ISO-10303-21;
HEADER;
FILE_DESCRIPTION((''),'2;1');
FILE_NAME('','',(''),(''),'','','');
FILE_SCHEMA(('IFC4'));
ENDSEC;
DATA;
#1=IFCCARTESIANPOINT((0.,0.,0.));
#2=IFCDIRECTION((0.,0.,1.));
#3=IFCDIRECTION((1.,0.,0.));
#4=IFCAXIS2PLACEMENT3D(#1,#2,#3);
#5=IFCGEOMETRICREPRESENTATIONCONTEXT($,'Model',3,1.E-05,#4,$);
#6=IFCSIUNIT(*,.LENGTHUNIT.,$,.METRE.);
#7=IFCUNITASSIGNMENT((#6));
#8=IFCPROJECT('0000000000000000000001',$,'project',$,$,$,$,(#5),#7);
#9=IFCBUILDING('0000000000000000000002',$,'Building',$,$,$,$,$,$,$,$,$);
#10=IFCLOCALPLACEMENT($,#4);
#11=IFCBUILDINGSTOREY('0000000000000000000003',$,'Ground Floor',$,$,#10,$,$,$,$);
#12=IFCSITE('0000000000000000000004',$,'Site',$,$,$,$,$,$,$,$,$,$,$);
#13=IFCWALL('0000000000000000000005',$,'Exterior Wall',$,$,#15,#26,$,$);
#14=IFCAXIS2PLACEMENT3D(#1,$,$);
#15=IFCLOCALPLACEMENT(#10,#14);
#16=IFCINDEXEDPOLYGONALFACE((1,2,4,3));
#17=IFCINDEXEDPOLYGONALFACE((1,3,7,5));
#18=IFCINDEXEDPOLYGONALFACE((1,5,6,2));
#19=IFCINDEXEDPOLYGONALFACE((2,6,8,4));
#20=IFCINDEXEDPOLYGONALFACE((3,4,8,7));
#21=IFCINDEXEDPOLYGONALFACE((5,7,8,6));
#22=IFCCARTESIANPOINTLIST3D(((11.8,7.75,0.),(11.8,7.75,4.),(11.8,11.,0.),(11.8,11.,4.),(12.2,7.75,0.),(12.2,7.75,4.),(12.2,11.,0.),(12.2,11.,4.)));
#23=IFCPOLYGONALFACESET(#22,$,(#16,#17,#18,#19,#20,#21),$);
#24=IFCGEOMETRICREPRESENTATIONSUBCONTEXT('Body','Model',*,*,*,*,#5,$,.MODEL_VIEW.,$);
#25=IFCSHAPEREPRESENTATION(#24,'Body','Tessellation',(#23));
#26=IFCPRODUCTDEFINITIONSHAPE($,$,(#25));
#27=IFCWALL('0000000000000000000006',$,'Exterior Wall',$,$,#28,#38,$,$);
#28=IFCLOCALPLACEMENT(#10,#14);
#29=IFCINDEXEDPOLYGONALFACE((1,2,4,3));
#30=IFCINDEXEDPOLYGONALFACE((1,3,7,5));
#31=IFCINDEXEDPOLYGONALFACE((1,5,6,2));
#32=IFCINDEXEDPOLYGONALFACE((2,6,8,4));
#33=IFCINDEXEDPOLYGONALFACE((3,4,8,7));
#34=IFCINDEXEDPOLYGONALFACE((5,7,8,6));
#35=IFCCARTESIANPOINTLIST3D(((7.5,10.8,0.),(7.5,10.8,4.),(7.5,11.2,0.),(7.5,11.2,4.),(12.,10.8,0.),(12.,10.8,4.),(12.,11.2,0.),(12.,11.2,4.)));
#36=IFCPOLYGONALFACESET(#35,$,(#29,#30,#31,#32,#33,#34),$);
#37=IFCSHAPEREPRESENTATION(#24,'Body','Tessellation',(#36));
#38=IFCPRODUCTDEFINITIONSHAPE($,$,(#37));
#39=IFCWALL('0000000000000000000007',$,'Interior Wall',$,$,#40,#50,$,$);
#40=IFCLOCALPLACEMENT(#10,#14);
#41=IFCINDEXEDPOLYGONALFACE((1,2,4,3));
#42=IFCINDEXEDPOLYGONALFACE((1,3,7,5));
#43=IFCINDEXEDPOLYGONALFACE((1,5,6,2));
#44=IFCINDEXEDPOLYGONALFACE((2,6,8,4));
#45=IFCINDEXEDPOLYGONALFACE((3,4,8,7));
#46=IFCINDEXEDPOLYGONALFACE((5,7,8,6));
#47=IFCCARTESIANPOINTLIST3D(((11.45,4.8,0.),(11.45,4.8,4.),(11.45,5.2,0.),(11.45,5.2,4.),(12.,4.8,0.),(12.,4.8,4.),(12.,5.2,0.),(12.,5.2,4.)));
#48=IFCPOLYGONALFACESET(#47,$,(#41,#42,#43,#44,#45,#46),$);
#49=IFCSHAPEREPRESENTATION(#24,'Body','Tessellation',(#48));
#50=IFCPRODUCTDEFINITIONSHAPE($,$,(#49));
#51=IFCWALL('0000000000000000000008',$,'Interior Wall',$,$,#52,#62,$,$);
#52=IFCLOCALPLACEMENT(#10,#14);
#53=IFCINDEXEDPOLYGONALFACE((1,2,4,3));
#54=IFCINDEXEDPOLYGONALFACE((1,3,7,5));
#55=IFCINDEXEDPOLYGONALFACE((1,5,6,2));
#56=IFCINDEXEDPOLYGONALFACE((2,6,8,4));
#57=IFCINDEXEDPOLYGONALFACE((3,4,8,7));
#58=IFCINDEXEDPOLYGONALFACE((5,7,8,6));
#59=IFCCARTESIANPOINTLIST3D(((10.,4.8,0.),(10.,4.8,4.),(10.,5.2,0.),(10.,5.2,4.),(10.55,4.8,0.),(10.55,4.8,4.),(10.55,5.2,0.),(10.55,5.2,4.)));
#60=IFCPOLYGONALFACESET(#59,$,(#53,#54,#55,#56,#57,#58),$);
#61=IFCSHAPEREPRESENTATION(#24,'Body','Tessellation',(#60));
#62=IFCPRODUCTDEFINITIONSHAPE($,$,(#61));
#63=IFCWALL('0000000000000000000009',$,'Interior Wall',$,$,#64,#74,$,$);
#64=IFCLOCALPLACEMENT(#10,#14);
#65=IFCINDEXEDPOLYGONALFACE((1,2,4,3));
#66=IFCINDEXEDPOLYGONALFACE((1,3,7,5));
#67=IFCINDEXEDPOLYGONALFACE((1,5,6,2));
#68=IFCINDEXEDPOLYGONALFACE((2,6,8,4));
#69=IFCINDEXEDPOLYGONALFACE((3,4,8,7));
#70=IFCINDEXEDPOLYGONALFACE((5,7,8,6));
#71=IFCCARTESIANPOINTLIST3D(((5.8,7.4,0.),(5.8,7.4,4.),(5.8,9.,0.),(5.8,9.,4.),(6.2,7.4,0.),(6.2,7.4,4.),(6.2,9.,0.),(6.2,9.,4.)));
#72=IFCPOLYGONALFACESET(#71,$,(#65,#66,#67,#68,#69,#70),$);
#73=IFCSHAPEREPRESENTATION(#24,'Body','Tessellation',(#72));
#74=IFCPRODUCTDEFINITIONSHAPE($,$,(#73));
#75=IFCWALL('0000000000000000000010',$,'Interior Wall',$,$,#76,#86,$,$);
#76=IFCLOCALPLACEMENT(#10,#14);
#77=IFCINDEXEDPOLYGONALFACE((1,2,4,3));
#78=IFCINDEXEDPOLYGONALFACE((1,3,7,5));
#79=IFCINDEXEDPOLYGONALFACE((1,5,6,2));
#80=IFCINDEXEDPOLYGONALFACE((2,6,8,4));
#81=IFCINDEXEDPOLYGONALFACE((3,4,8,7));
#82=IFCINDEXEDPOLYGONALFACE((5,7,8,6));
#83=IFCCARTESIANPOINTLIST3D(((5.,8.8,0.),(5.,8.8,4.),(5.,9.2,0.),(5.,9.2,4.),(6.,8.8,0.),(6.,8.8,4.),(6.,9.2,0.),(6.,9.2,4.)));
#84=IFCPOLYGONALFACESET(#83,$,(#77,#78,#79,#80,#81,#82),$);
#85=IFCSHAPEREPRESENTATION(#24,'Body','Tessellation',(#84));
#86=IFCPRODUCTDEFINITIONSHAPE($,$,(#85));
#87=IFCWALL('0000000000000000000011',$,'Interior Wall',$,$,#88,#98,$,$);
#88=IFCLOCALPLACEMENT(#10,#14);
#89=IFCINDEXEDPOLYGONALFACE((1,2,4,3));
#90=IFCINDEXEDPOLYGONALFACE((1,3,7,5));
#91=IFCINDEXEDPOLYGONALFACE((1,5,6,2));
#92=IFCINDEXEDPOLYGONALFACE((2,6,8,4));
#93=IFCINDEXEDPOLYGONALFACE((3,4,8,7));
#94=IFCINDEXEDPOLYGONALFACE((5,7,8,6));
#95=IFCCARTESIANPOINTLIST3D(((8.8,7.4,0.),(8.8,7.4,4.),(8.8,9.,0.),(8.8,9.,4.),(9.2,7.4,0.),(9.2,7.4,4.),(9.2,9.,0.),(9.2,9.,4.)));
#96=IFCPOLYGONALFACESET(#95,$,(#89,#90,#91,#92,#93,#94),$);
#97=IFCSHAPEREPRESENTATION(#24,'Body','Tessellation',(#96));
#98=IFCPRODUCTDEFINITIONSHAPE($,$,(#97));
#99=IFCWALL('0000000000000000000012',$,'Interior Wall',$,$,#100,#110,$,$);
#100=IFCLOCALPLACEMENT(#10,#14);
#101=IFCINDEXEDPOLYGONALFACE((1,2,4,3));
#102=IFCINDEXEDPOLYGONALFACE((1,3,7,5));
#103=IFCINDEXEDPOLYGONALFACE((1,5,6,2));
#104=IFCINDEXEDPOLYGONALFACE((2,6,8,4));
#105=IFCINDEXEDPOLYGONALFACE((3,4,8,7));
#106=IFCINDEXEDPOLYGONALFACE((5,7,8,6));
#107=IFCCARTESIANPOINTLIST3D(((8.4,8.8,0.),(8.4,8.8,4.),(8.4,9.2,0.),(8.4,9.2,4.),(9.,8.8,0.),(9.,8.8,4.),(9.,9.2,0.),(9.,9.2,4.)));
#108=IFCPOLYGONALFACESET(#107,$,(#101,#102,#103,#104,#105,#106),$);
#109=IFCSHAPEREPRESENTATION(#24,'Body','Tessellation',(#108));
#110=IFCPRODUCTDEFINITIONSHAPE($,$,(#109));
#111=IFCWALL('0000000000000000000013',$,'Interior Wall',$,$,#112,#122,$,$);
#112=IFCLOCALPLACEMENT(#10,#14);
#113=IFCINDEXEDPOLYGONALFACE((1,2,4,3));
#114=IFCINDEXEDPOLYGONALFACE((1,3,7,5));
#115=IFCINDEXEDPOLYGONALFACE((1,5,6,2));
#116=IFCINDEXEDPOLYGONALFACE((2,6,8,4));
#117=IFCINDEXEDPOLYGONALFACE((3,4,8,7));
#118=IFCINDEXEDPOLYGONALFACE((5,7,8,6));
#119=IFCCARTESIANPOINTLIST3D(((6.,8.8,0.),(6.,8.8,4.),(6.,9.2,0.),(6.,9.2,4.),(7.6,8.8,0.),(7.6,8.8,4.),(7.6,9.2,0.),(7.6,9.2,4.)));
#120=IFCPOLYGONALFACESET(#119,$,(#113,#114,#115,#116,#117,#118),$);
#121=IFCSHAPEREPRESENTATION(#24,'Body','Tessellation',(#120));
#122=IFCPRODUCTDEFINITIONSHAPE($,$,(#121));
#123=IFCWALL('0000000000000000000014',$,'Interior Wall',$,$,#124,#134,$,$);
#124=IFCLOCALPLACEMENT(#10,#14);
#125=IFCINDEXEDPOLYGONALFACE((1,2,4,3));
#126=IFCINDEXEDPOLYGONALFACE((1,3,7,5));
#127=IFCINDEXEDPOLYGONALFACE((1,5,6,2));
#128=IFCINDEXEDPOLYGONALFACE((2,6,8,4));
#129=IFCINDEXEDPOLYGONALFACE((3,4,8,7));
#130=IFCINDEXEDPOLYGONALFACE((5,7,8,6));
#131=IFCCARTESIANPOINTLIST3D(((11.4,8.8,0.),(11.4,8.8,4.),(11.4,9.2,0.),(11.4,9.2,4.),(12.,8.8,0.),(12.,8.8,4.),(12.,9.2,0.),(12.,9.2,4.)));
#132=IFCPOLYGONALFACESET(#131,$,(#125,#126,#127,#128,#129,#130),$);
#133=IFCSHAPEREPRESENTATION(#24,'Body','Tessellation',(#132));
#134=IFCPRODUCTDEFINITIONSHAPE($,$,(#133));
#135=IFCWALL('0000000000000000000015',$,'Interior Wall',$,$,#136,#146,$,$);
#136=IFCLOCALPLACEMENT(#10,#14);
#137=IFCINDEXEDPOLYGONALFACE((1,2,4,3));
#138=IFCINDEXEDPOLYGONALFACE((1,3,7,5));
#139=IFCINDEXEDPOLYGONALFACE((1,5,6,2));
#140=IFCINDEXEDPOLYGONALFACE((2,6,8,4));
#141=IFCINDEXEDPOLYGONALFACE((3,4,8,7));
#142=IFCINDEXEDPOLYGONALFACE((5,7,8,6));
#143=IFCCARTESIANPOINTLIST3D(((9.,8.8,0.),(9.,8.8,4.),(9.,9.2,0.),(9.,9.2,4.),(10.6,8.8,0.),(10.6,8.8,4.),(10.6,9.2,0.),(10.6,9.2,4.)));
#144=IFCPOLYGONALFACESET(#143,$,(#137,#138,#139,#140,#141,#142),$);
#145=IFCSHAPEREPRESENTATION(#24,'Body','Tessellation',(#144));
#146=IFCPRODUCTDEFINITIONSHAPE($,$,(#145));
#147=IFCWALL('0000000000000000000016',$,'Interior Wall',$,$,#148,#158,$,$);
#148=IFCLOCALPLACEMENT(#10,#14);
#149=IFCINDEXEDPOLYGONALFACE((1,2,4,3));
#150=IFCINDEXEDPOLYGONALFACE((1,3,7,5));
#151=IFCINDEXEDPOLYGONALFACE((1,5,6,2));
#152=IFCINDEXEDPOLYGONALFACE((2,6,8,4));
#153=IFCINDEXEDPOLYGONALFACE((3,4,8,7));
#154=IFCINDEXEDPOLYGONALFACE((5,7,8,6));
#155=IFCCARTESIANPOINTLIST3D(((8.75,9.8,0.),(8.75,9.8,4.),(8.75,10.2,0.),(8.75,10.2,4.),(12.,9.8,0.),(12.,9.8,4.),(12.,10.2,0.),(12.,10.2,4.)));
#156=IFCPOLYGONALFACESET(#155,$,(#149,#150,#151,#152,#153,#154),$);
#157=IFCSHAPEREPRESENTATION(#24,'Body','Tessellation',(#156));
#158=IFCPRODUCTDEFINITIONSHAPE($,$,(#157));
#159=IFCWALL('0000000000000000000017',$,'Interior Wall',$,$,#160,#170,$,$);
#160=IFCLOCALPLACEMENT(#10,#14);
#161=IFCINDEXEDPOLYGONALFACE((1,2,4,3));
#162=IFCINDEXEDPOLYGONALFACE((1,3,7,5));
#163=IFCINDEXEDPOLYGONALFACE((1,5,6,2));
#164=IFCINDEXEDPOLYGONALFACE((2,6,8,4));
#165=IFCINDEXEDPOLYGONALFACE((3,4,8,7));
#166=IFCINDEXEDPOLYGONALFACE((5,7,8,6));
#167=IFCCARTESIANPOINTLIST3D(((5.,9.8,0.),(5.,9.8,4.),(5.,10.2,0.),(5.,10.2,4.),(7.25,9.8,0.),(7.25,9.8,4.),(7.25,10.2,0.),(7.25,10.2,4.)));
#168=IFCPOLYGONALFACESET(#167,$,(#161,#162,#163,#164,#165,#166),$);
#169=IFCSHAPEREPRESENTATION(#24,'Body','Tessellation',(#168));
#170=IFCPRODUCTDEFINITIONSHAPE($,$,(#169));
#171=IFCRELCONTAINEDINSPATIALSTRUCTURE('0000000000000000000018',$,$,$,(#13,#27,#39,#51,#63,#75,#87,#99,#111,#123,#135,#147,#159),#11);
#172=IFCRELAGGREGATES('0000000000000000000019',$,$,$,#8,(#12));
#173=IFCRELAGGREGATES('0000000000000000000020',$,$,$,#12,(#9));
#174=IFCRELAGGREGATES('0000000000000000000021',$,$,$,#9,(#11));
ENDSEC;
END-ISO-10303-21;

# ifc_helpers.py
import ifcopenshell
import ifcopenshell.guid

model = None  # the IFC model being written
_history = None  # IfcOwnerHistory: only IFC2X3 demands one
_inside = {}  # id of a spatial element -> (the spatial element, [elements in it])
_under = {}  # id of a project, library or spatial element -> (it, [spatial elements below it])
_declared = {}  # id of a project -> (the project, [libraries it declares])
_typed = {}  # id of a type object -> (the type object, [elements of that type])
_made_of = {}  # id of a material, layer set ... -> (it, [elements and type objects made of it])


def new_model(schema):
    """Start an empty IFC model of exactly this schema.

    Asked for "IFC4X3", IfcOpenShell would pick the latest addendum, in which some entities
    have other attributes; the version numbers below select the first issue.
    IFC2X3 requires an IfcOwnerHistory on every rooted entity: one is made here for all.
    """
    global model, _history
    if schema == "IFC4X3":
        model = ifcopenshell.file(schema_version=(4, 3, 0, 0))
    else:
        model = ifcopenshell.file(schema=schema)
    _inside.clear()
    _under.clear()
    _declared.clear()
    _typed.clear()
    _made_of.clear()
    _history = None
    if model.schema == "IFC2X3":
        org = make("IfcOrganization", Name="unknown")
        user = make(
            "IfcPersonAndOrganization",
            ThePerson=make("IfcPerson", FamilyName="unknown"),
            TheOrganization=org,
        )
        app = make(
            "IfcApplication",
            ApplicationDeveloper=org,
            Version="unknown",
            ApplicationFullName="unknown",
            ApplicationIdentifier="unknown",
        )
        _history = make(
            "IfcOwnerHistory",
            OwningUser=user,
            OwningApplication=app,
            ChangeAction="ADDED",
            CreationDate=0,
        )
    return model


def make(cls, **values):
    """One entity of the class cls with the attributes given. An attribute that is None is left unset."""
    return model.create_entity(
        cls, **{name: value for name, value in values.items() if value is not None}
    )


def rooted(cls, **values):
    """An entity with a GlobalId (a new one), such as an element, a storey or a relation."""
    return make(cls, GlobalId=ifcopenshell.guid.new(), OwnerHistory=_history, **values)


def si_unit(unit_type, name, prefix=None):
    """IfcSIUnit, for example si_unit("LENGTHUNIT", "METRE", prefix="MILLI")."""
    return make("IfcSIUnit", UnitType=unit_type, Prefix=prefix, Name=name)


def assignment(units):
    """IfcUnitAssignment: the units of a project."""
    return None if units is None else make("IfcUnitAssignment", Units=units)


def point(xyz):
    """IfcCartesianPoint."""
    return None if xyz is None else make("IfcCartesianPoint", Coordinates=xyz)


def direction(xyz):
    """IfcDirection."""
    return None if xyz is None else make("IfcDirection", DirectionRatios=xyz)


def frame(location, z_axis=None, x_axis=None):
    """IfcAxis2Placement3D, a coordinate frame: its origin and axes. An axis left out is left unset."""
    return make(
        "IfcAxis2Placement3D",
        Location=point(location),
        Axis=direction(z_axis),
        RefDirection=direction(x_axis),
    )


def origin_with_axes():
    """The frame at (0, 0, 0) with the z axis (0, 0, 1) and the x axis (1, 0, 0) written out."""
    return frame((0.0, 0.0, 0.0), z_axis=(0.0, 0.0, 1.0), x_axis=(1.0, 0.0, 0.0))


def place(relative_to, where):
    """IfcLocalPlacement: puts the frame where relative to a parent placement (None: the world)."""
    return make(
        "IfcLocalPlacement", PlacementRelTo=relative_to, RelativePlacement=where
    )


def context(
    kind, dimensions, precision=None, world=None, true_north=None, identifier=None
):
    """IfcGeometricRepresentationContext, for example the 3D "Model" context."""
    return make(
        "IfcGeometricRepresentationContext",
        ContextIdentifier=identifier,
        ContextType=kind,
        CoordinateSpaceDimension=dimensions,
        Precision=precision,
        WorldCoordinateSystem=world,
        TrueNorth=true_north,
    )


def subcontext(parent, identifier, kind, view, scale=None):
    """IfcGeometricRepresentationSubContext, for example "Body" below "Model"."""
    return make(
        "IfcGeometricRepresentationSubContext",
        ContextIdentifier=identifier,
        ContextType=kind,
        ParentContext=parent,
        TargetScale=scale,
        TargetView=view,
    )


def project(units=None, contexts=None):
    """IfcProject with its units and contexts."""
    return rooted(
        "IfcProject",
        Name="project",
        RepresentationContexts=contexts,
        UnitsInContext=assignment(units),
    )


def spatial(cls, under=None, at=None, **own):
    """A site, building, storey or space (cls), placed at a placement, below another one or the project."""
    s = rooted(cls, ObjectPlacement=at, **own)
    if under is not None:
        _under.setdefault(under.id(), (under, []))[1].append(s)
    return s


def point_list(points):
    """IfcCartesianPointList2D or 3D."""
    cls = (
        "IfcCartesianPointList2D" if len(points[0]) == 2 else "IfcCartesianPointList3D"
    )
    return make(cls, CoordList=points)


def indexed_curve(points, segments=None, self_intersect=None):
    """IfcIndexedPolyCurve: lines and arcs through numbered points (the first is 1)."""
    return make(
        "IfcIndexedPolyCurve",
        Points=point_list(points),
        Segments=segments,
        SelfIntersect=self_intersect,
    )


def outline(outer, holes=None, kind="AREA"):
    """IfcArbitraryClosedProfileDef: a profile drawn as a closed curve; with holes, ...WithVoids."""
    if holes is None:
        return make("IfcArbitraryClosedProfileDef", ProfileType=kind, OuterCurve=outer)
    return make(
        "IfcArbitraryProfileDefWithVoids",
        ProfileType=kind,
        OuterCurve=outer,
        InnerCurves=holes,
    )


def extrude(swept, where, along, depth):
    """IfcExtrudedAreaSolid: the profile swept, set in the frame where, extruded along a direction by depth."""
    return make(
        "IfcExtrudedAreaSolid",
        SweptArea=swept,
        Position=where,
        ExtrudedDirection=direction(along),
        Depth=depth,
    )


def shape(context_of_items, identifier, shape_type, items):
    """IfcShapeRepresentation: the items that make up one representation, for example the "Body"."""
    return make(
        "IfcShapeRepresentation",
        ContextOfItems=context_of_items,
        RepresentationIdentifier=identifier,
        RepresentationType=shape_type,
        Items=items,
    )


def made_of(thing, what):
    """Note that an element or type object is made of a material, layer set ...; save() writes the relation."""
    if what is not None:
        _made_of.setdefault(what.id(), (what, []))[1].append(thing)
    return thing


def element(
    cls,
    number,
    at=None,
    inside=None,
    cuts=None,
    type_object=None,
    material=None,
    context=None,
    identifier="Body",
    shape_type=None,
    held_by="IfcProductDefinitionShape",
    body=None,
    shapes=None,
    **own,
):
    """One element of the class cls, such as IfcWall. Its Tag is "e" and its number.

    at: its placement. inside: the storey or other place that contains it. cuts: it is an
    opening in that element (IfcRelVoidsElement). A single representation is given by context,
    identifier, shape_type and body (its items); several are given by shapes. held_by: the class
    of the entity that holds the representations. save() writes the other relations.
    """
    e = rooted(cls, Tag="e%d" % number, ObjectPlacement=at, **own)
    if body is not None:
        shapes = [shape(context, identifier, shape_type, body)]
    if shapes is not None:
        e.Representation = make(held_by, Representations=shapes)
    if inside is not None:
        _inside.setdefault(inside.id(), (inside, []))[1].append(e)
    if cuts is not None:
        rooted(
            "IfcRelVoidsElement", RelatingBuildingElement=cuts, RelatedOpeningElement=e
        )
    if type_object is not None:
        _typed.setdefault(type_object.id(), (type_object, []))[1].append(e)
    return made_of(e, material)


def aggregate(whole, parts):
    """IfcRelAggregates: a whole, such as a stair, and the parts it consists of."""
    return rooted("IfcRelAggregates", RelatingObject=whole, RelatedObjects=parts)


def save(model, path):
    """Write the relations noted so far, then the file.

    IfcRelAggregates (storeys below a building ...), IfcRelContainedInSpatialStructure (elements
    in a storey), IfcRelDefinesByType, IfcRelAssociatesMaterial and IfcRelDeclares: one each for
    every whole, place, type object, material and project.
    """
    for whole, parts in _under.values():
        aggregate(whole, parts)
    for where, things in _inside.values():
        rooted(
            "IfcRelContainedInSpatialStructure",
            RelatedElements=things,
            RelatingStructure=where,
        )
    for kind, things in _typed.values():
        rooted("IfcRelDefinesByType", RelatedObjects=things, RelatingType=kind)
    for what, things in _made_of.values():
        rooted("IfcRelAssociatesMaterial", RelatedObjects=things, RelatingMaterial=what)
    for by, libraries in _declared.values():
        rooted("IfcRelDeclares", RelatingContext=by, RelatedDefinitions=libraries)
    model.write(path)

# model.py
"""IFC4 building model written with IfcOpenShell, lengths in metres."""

from ifc_helpers import new_model, si_unit, frame, origin_with_axes, place, context, subcontext, project, spatial, indexed_curve, outline, extrude, element, save


model = new_model("IFC4")

# Units and contexts
model_context = context("Model", 3, precision=1e-05, world=origin_with_axes())
body_context = subcontext(model_context, "Body", "Model", "MODEL_VIEW")
ifc_project = project(units=[si_unit("LENGTHUNIT", "METRE")], contexts=[model_context])

# Site, building, storey
site = spatial("IfcSite", under=ifc_project, Name="Site")
building = spatial("IfcBuilding", under=site, Name="Building")
storey_placement = place(None, origin_with_axes())
storey = spatial("IfcBuildingStorey", under=building, at=storey_placement, Name="Ground Floor")

# Walls
wall_1_placement = place(storey_placement, frame((12.0, 7.75, 0.0), z_axis=(0.0, 0.0, 1.0), x_axis=(0.0, 1.0, 0.0)))
element("IfcWall", 1, at=wall_1_placement, inside=storey, Name="Exterior Wall", context=body_context, shape_type="SweptSolid", body=[
    extrude(outline(indexed_curve([(0.0, 0.0), (0.0, 0.4), (3.25, 0.4), (3.25, 0.0), (0.0, 0.0)], self_intersect=False)), frame((0.0, -0.2, 0.0), z_axis=(0.0, 0.0, 1.0), x_axis=(1.0, 0.0, 0.0)), (0.0, 0.0, 1.0), 4.0),
])
wall_2_placement = place(storey_placement, frame((12.0, 11.0, 0.0), z_axis=(0.0, 0.0, 1.0), x_axis=(-1.0, 0.0, 0.0)))
element("IfcWall", 2, at=wall_2_placement, inside=storey, Name="Exterior Wall", context=body_context, shape_type="SweptSolid", body=[
    extrude(outline(indexed_curve([(0.0, 0.0), (0.0, 0.4), (4.5, 0.4), (4.5, 0.0), (0.0, 0.0)], self_intersect=False)), frame((0.0, -0.2, 0.0), z_axis=(0.0, 0.0, 1.0), x_axis=(1.0, 0.0, 0.0)), (0.0, 0.0, 1.0), 4.0),
])
for number, where, z_axis, x_axis, name in (
    (3, (12.0, 5.0, 0.0), (0.0, 0.0, 1.0), (-1.0, 0.0, 0.0), "Interior Wall"),
    (4, (10.55, 5.0, 0.0), (0.0, 0.0, 1.0), (-1.0, 0.0, 0.0), "Interior Wall"),
):
    element("IfcWall", number, at=place(storey_placement, frame(where, z_axis=z_axis, x_axis=x_axis)), inside=storey, Name=name, context=body_context, shape_type="SweptSolid", body=[
        extrude(outline(indexed_curve([(0.0, 0.0), (0.0, 0.4), (0.55, 0.4), (0.55, 0.0), (0.0, 0.0)], self_intersect=False)), frame((0.0, -0.2, 0.0), z_axis=(0.0, 0.0, 1.0), x_axis=(1.0, 0.0, 0.0)), (0.0, 0.0, 1.0), 4.0),
    ])
wall_3_placement = place(storey_placement, frame((6.0, 7.4, 0.0), z_axis=(0.0, 0.0, 1.0), x_axis=(0.0, 1.0, 0.0)))
element("IfcWall", 5, at=wall_3_placement, inside=storey, Name="Interior Wall", context=body_context, shape_type="SweptSolid", body=[
    extrude(outline(indexed_curve([(0.0, 0.0), (0.0, 0.4), (1.6, 0.4), (1.6, 0.0), (0.0, 0.0)], self_intersect=False)), frame((0.0, -0.2, 0.0), z_axis=(0.0, 0.0, 1.0), x_axis=(1.0, 0.0, 0.0)), (0.0, 0.0, 1.0), 4.0),
])
wall_4_placement = place(storey_placement, frame((6.0, 9.0, 0.0), z_axis=(0.0, 0.0, 1.0), x_axis=(-1.0, 0.0, 0.0)))
element("IfcWall", 6, at=wall_4_placement, inside=storey, Name="Interior Wall", context=body_context, shape_type="SweptSolid", body=[
    extrude(outline(indexed_curve([(0.0, 0.0), (0.0, 0.4), (1.0, 0.4), (1.0, 0.0), (0.0, 0.0)], self_intersect=False)), frame((0.0, -0.2, 0.0), z_axis=(0.0, 0.0, 1.0), x_axis=(1.0, 0.0, 0.0)), (0.0, 0.0, 1.0), 4.0),
])
wall_5_placement = place(storey_placement, frame((9.0, 7.4, 0.0), z_axis=(0.0, 0.0, 1.0), x_axis=(0.0, 1.0, 0.0)))
element("IfcWall", 7, at=wall_5_placement, inside=storey, Name="Interior Wall", context=body_context, shape_type="SweptSolid", body=[
    extrude(outline(indexed_curve([(0.0, 0.0), (0.0, 0.4), (1.6, 0.4), (1.6, 0.0), (0.0, 0.0)], self_intersect=False)), frame((0.0, -0.2, 0.0), z_axis=(0.0, 0.0, 1.0), x_axis=(1.0, 0.0, 0.0)), (0.0, 0.0, 1.0), 4.0),
])
wall_6_placement = place(storey_placement, frame((9.0, 9.0, 0.0), z_axis=(0.0, 0.0, 1.0), x_axis=(-1.0, 0.0, 0.0)))
element("IfcWall", 8, at=wall_6_placement, inside=storey, Name="Interior Wall", context=body_context, shape_type="SweptSolid", body=[
    extrude(outline(indexed_curve([(0.0, 0.0), (0.0, 0.4), (0.6, 0.4), (0.6, 0.0), (0.0, 0.0)], self_intersect=False)), frame((0.0, -0.2, 0.0), z_axis=(0.0, 0.0, 1.0), x_axis=(1.0, 0.0, 0.0)), (0.0, 0.0, 1.0), 4.0),
])
wall_7_placement = place(storey_placement, frame((7.6, 9.0, 0.0), z_axis=(0.0, 0.0, 1.0), x_axis=(-1.0, 0.0, 0.0)))
element("IfcWall", 9, at=wall_7_placement, inside=storey, Name="Interior Wall", context=body_context, shape_type="SweptSolid", body=[
    extrude(outline(indexed_curve([(0.0, 0.0), (0.0, 0.4), (1.6, 0.4), (1.6, 0.0), (0.0, 0.0)], self_intersect=False)), frame((0.0, -0.2, 0.0), z_axis=(0.0, 0.0, 1.0), x_axis=(1.0, 0.0, 0.0)), (0.0, 0.0, 1.0), 4.0),
])
wall_8_placement = place(storey_placement, frame((12.0, 9.0, 0.0), z_axis=(0.0, 0.0, 1.0), x_axis=(-1.0, 0.0, 0.0)))
element("IfcWall", 10, at=wall_8_placement, inside=storey, Name="Interior Wall", context=body_context, shape_type="SweptSolid", body=[
    extrude(outline(indexed_curve([(0.0, 0.0), (0.0, 0.4), (0.6, 0.4), (0.6, 0.0), (0.0, 0.0)], self_intersect=False)), frame((0.0, -0.2, 0.0), z_axis=(0.0, 0.0, 1.0), x_axis=(1.0, 0.0, 0.0)), (0.0, 0.0, 1.0), 4.0),
])
wall_9_placement = place(storey_placement, frame((10.6, 9.0, 0.0), z_axis=(0.0, 0.0, 1.0), x_axis=(-1.0, 0.0, 0.0)))
element("IfcWall", 11, at=wall_9_placement, inside=storey, Name="Interior Wall", context=body_context, shape_type="SweptSolid", body=[
    extrude(outline(indexed_curve([(0.0, 0.0), (0.0, 0.4), (1.6, 0.4), (1.6, 0.0), (0.0, 0.0)], self_intersect=False)), frame((0.0, -0.2, 0.0), z_axis=(0.0, 0.0, 1.0), x_axis=(1.0, 0.0, 0.0)), (0.0, 0.0, 1.0), 4.0),
])
wall_10_placement = place(storey_placement, frame((12.0, 10.0, 0.0), z_axis=(0.0, 0.0, 1.0), x_axis=(-1.0, 0.0, 0.0)))
element("IfcWall", 12, at=wall_10_placement, inside=storey, Name="Interior Wall", context=body_context, shape_type="SweptSolid", body=[
    extrude(outline(indexed_curve([(0.0, 0.0), (0.0, 0.4), (3.25, 0.4), (3.25, 0.0), (0.0, 0.0)], self_intersect=False)), frame((0.0, -0.2, 0.0), z_axis=(0.0, 0.0, 1.0), x_axis=(1.0, 0.0, 0.0)), (0.0, 0.0, 1.0), 4.0),
])
wall_11_placement = place(storey_placement, frame((7.25, 10.0, 0.0), z_axis=(0.0, 0.0, 1.0), x_axis=(-1.0, 0.0, 0.0)))
element("IfcWall", 13, at=wall_11_placement, inside=storey, Name="Interior Wall", context=body_context, shape_type="SweptSolid", body=[
    extrude(outline(indexed_curve([(0.0, 0.0), (0.0, 0.4), (2.25, 0.4), (2.25, 0.0), (0.0, 0.0)], self_intersect=False)), frame((0.0, -0.2, 0.0), z_axis=(0.0, 0.0, 1.0), x_axis=(1.0, 0.0, 0.0)), (0.0, 0.0, 1.0), 4.0),
])

save(model, "model.ifc")
